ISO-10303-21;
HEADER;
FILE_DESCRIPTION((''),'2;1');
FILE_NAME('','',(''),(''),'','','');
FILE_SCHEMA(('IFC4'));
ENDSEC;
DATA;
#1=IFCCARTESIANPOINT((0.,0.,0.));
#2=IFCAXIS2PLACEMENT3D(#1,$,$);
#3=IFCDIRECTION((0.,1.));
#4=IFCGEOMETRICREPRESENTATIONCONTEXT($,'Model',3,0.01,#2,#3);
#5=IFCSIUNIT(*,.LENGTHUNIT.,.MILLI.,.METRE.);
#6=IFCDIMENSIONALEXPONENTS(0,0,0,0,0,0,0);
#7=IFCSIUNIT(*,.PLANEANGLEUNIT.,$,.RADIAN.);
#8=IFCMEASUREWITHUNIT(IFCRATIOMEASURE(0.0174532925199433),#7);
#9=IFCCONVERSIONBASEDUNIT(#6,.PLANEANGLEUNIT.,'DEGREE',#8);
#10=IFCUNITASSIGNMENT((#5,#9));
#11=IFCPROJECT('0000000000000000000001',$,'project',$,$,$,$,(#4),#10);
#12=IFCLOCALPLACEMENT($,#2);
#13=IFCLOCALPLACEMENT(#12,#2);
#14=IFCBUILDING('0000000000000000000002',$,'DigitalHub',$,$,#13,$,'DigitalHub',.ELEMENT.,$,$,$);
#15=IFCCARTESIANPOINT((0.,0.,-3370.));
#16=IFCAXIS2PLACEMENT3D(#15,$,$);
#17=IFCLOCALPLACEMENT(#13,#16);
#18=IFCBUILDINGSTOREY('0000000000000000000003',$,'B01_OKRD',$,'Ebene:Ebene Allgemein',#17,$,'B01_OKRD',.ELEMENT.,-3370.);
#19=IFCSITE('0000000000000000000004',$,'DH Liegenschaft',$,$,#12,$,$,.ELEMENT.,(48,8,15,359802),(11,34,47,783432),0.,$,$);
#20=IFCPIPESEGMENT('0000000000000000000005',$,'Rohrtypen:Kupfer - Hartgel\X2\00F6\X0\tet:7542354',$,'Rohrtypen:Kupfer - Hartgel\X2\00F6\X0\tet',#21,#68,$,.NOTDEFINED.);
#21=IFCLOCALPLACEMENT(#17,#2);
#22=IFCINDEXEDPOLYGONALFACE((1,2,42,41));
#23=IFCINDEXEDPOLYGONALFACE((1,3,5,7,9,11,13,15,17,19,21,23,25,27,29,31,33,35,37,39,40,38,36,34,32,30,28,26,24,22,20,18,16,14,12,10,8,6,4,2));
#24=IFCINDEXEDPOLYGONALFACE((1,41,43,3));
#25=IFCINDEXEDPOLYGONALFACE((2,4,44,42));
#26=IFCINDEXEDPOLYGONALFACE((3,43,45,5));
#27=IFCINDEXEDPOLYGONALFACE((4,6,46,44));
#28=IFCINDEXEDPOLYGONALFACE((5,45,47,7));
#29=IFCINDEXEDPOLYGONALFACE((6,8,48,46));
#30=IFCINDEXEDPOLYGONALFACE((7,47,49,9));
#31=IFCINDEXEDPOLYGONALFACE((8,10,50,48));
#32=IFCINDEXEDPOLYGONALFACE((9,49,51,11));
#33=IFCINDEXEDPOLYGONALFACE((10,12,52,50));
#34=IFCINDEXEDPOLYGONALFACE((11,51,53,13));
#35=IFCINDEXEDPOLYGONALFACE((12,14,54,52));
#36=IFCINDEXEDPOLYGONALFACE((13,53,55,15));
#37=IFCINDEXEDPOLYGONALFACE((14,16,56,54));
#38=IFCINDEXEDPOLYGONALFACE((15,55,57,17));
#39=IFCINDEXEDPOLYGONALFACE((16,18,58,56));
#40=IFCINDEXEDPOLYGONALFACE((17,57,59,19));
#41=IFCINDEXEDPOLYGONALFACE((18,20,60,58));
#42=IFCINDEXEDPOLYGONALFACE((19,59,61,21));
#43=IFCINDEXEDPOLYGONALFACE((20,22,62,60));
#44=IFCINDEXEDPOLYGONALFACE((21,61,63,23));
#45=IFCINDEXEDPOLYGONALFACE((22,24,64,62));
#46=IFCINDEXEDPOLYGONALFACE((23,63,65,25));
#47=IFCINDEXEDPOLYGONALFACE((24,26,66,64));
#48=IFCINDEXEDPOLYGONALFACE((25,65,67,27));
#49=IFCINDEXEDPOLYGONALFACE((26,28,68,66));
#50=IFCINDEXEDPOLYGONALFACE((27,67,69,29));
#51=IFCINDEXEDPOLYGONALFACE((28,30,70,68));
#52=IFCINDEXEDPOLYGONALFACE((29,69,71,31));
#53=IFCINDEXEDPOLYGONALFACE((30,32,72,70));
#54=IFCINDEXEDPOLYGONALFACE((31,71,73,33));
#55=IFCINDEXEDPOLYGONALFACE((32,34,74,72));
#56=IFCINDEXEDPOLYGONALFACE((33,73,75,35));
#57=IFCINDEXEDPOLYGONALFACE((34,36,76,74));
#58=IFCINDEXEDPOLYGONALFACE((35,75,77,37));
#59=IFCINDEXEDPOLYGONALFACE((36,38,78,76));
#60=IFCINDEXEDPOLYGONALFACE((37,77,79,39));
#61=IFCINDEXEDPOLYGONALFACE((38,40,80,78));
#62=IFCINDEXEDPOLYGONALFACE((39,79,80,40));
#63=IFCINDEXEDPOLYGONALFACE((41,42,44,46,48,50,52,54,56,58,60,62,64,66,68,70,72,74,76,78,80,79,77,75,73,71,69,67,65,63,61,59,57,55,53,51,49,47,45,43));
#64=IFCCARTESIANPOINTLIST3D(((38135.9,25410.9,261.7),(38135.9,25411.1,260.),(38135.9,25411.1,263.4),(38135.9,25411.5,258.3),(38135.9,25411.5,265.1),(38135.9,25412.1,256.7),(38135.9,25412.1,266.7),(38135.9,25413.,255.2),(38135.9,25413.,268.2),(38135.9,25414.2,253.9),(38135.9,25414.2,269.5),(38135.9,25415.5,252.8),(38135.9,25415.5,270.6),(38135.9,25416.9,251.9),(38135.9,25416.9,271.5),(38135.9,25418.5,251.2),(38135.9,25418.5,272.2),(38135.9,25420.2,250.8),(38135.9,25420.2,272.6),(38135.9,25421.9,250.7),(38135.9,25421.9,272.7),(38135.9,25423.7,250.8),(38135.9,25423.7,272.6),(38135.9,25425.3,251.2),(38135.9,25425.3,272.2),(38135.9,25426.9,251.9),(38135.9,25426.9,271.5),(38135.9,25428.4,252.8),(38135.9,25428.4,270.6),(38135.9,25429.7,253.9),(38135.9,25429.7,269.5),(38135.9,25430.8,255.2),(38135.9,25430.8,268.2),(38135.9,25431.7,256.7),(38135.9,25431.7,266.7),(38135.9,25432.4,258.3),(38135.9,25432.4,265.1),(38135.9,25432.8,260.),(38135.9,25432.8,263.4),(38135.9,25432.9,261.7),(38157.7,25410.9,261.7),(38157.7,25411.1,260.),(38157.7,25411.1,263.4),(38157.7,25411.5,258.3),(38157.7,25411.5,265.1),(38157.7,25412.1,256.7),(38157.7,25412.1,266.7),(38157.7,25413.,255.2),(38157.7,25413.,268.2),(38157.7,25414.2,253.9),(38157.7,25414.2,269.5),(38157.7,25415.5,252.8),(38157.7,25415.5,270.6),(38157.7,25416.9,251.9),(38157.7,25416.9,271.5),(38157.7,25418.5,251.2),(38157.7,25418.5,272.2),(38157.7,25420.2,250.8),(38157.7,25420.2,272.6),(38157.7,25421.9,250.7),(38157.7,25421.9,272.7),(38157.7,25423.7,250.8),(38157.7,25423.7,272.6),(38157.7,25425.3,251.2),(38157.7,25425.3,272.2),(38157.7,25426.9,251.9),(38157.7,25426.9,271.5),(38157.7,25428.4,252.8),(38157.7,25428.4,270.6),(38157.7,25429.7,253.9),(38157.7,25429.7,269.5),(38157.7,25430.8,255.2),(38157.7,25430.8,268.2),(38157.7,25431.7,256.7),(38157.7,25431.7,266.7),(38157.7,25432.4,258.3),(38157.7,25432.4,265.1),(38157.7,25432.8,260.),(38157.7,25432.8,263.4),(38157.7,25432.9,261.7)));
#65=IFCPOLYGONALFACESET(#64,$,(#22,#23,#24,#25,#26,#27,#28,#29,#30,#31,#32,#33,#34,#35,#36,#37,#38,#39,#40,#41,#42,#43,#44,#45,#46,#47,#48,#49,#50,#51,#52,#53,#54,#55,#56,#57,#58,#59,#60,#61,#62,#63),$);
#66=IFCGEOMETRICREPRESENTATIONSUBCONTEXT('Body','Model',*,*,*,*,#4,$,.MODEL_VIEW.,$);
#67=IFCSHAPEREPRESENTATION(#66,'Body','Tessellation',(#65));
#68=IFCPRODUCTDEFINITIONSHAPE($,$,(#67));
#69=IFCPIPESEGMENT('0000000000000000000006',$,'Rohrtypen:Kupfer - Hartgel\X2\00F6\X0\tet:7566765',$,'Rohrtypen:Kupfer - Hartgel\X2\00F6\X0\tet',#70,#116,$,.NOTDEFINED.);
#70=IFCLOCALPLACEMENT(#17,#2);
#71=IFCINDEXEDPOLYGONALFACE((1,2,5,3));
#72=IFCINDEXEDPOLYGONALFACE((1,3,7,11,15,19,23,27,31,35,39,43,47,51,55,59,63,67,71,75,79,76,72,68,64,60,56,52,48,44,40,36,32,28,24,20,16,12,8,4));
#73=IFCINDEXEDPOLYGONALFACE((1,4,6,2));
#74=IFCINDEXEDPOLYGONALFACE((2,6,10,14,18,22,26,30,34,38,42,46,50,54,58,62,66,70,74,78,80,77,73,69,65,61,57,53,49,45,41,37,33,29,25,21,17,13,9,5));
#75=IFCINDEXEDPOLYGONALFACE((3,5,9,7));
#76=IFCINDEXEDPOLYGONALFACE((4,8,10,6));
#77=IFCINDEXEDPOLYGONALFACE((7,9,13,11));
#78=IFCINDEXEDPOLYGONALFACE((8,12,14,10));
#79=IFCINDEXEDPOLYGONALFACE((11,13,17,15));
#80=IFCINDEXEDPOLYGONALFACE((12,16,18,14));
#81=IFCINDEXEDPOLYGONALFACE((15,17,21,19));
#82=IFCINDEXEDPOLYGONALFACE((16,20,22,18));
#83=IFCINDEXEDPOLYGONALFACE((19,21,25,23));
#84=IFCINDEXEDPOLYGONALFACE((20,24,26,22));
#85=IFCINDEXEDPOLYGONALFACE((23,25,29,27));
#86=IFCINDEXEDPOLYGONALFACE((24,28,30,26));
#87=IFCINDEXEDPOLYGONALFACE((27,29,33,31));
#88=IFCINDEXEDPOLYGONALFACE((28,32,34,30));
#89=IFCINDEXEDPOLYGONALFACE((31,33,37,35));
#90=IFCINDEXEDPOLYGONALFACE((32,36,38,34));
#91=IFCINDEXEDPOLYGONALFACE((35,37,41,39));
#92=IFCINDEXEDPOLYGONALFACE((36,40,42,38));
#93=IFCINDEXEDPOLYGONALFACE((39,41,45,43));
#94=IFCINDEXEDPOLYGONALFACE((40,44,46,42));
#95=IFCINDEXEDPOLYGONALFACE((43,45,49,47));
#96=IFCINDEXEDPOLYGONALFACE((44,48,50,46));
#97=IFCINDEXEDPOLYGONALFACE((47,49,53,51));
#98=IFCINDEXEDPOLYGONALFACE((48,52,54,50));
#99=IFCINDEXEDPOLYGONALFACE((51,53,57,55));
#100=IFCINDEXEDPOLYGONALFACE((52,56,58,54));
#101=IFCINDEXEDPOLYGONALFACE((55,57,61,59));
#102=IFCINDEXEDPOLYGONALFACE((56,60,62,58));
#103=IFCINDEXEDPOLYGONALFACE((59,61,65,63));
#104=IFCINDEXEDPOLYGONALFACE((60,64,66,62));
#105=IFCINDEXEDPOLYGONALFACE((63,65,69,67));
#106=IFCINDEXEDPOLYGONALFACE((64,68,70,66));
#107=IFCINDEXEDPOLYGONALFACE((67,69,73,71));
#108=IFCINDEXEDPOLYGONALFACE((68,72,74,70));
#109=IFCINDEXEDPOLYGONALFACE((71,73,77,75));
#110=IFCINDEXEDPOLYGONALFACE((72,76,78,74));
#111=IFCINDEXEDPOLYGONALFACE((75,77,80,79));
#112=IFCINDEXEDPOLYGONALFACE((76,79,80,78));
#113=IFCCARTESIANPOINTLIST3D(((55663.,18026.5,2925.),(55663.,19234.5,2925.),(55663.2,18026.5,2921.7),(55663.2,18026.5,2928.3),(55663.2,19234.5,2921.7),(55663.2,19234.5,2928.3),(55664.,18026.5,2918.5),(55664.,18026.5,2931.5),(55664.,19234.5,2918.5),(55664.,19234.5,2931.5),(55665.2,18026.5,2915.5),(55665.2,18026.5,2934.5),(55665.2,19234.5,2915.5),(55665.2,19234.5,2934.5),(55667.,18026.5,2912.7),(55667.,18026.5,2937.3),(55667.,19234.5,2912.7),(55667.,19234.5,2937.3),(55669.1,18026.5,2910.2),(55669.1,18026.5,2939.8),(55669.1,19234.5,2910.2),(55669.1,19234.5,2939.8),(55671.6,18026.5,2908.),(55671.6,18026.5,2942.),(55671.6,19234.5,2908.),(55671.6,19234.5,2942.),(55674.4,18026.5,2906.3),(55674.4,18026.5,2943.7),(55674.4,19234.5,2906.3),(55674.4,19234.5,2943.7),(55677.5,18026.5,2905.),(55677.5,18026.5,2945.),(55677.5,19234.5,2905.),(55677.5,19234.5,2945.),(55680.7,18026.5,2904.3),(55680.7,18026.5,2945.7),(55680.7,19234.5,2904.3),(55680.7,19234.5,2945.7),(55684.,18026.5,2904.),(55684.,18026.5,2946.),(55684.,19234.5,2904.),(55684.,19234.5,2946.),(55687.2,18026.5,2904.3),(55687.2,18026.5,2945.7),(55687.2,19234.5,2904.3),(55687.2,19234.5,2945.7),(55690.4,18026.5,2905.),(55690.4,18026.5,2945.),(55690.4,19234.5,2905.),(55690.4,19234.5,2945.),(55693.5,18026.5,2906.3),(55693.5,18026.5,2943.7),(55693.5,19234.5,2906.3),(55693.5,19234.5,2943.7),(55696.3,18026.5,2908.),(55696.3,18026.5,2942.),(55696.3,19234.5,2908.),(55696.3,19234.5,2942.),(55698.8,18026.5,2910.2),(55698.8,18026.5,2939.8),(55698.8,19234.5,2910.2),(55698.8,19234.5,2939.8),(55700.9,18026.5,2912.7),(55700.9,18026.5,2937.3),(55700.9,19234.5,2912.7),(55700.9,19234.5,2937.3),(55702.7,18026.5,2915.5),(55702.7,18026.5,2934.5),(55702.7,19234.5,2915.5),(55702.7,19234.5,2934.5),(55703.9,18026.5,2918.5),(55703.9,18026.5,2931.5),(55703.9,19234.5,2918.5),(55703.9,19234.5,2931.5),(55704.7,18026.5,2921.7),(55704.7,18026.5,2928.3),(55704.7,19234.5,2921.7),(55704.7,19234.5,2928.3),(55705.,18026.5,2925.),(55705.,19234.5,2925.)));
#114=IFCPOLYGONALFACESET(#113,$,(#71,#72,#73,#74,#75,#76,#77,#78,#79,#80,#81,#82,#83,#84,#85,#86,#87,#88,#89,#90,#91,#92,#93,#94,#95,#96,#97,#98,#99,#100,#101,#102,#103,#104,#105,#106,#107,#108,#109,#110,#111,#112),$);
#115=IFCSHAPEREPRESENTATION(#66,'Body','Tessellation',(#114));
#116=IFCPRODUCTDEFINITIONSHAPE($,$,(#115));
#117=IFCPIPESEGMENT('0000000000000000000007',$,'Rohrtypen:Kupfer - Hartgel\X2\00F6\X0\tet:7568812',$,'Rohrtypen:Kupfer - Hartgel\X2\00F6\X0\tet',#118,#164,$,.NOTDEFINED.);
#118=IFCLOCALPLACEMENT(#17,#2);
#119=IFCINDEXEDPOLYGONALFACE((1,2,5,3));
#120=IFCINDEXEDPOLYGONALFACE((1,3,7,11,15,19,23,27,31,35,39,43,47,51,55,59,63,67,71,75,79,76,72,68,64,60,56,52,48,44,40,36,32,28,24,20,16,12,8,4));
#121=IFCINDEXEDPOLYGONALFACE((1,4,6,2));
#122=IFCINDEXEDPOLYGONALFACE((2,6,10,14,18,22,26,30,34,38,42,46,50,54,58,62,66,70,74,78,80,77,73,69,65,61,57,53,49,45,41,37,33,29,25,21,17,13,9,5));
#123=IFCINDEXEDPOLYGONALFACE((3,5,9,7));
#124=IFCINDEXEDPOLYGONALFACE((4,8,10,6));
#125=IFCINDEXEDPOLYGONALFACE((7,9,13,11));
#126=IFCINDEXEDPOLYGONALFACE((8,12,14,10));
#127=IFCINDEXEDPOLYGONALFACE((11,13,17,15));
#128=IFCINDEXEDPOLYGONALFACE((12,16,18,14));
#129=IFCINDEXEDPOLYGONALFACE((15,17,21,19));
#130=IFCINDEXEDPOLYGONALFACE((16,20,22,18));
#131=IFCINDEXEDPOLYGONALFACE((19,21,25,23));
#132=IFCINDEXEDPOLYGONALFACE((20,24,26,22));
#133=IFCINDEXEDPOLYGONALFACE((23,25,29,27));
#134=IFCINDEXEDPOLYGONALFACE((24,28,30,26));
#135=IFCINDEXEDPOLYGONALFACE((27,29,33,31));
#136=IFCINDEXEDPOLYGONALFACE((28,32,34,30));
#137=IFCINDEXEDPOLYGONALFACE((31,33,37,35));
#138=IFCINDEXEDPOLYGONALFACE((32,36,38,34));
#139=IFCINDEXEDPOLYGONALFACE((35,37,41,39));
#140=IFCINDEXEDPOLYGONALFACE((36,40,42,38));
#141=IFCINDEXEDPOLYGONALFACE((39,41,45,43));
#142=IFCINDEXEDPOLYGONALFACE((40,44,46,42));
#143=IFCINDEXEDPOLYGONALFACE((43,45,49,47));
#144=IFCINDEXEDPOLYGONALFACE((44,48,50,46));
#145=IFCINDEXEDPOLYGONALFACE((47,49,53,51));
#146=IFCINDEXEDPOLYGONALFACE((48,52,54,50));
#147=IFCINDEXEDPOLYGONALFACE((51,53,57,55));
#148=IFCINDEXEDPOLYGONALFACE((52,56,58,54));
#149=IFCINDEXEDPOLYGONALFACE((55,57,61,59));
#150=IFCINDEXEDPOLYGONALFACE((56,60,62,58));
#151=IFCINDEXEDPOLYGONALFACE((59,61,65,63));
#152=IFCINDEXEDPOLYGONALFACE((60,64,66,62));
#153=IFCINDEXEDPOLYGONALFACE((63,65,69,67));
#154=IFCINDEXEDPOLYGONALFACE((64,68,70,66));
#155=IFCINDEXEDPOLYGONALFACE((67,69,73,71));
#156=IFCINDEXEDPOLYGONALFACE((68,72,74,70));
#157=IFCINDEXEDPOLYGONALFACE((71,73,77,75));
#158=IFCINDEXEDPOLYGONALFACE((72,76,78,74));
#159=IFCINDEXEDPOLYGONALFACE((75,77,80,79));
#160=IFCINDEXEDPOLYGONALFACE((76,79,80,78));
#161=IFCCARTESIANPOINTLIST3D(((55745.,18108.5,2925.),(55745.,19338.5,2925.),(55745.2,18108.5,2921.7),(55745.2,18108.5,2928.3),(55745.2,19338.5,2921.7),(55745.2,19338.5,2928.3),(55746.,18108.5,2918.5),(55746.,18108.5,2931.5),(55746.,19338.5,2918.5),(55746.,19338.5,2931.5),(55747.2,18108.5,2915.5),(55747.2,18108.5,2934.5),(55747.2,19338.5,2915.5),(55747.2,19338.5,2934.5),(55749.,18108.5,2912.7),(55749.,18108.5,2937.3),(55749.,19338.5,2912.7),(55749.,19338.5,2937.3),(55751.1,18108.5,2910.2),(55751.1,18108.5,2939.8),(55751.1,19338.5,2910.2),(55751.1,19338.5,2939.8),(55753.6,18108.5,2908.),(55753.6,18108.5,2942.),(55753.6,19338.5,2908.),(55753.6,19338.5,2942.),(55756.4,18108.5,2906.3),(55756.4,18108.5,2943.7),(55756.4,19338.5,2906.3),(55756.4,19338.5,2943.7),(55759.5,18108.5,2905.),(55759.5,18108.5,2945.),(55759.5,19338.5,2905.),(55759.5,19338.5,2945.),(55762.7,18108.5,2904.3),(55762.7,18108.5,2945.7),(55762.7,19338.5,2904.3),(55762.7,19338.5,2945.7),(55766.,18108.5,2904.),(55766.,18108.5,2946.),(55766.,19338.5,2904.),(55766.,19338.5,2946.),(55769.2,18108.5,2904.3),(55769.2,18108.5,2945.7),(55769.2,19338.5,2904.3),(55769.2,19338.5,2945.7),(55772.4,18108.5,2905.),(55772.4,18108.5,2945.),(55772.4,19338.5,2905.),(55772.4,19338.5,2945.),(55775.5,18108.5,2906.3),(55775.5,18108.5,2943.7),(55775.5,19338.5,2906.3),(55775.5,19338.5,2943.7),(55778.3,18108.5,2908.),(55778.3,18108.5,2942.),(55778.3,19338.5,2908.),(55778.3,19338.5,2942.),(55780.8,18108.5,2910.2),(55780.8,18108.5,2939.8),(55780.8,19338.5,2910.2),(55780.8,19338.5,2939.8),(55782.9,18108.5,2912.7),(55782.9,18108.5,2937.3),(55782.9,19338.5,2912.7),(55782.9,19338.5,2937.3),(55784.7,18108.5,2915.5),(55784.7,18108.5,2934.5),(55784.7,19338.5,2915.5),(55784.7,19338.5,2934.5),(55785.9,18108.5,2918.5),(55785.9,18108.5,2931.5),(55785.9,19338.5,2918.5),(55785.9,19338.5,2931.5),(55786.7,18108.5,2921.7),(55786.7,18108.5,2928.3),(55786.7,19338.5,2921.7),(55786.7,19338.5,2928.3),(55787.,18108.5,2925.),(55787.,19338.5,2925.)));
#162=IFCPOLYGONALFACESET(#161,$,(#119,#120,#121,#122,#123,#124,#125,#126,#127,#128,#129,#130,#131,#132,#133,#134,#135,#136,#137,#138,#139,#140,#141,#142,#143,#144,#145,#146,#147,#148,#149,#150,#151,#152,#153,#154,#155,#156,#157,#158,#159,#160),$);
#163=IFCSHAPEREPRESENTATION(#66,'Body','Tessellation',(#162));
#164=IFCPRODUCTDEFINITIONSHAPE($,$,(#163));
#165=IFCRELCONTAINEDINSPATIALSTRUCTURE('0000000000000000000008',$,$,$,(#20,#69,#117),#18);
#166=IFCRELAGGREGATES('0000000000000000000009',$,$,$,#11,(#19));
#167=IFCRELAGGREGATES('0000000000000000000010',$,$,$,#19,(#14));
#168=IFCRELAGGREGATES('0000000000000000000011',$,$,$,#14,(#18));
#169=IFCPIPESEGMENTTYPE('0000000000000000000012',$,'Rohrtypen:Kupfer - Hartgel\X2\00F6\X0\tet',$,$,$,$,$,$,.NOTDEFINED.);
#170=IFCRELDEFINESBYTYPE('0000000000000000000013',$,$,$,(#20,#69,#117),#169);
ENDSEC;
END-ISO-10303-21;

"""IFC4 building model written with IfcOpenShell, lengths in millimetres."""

from ifc_helpers import new_model, entity, si_unit, converted_unit, direction, frame, origin, place, context, subcontext, project, spatial, indexed_curve, outline, extrude, type_object, element, save


model = new_model("IFC4")

# Units and contexts
model_context = context("Model", 3, precision=0.01, world=origin(), true_north=direction((0.0, 1.0)))
body_context = subcontext(model_context, "Body", "Model", "MODEL_VIEW")
ifc_project = project(units=[si_unit("LENGTHUNIT", "METRE", prefix="MILLI"), converted_unit("PLANEANGLEUNIT", "DEGREE", entity("IfcRatioMeasure", 0.0174532925199433), si_unit("PLANEANGLEUNIT", "RADIAN"), dimensions=[0, 0, 0, 0, 0, 0, 0])], contexts=[model_context])

# Site, building, storey
site_placement = place(None, origin())
site = spatial("IfcSite", under=ifc_project, at=site_placement, Name="DH Liegenschaft", CompositionType="ELEMENT", RefLatitude=(48, 8, 15, 359802), RefLongitude=(11, 34, 47, 783432), RefElevation=0.0)
building_placement = place(site_placement, origin())
building = spatial("IfcBuilding", under=site, at=building_placement, Name="DigitalHub", LongName="DigitalHub", CompositionType="ELEMENT")
storey_placement = place(building_placement, frame((0.0, 0.0, -3370.0)))
storey = spatial("IfcBuildingStorey", under=building, at=storey_placement, Name="B01_OKRD", ObjectType="Ebene:Ebene Allgemein", LongName="B01_OKRD", CompositionType="ELEMENT", Elevation=-3370.0)

# Pipe segments
pipe_segment_type = type_object("IfcPipeSegmentType", Name="Rohrtypen:Kupfer - Hartgelötet", PredefinedType="NOTDEFINED")
pipe_segment_1_placement = place(storey_placement, frame((38135.9, 25409.3, 249.1)))
element("IfcPipeSegment", 1, at=pipe_segment_1_placement, inside=storey, type_object=pipe_segment_type, Name="Rohrtypen:Kupfer - Hartgelötet:7542354", ObjectType="Rohrtypen:Kupfer - Hartgelötet", PredefinedType="NOTDEFINED", context=body_context, shape_type="SweptSolid", body=[
    extrude(outline(indexed_curve([(11.0, 0.0), (10.9, 1.7), (10.5, 3.4), (9.8, 5.0), (8.9, 6.5), (7.8, 7.8), (6.5, 8.9), (5.0, 9.8), (3.4, 10.5), (1.7, 10.9), (0.0, 11.0), (-1.7, 10.9), (-3.4, 10.5), (-5.0, 9.8), (-6.5, 8.9), (-7.8, 7.8), (-8.9, 6.5), (-9.8, 5.0), (-10.5, 3.4), (-10.9, 1.7), (-11.0, 0.0), (-10.9, -1.7), (-10.5, -3.4), (-9.8, -5.0), (-8.9, -6.5), (-7.8, -7.8), (-6.5, -8.9), (-5.0, -9.8), (-3.4, -10.5), (-1.7, -10.9), (0.0, -11.0), (1.7, -10.9), (3.4, -10.5), (5.0, -9.8), (6.5, -8.9), (7.8, -7.8), (8.9, -6.5), (9.8, -5.0), (10.5, -3.4), (10.9, -1.7), (11.0, 0.0)], self_intersect=False)), frame((0.0, 12.6, 12.6), z_axis=(1.0, 0.0, 0.0), x_axis=(0.0, 1.0, 0.0)), (0.0, 0.0, 1.0), 21.8),
])
pipe_segment_2_placement = place(storey_placement, frame((55661.4, 18026.5, 2902.4)))
element("IfcPipeSegment", 2, at=pipe_segment_2_placement, inside=storey, type_object=pipe_segment_type, Name="Rohrtypen:Kupfer - Hartgelötet:7566765", ObjectType="Rohrtypen:Kupfer - Hartgelötet", PredefinedType="NOTDEFINED", context=body_context, shape_type="SweptSolid", body=[
    extrude(outline(indexed_curve([(21.0, 0.0), (20.7, 3.3), (20.0, 6.5), (18.7, 9.5), (17.0, 12.3), (14.8, 14.8), (12.3, 17.0), (9.5, 18.7), (6.5, 20.0), (3.3, 20.7), (0.0, 21.0), (-3.3, 20.7), (-6.5, 20.0), (-9.5, 18.7), (-12.3, 17.0), (-14.8, 14.8), (-17.0, 12.3), (-18.7, 9.5), (-20.0, 6.5), (-20.7, 3.3), (-21.0, 0.0), (-20.7, -3.3), (-20.0, -6.5), (-18.7, -9.5), (-17.0, -12.3), (-14.8, -14.8), (-12.3, -17.0), (-9.5, -18.7), (-6.5, -20.0), (-3.3, -20.7), (0.0, -21.0), (3.3, -20.7), (6.5, -20.0), (9.5, -18.7), (12.3, -17.0), (14.8, -14.8), (17.0, -12.3), (18.7, -9.5), (20.0, -6.5), (20.7, -3.3), (21.0, 0.0)], self_intersect=False)), frame((22.6, 0.0, 22.6), z_axis=(0.0, 1.0, 0.0), x_axis=(-1.0, 0.0, 0.0)), (0.0, 0.0, 1.0), 1208.0),
])
pipe_segment_3_placement = place(storey_placement, frame((55743.4, 18108.5, 2902.4)))
element("IfcPipeSegment", 3, at=pipe_segment_3_placement, inside=storey, type_object=pipe_segment_type, Name="Rohrtypen:Kupfer - Hartgelötet:7568812", ObjectType="Rohrtypen:Kupfer - Hartgelötet", PredefinedType="NOTDEFINED", context=body_context, shape_type="SweptSolid", body=[
    extrude(outline(indexed_curve([(21.0, 0.0), (20.7, 3.3), (20.0, 6.5), (18.7, 9.5), (17.0, 12.3), (14.8, 14.8), (12.3, 17.0), (9.5, 18.7), (6.5, 20.0), (3.3, 20.7), (0.0, 21.0), (-3.3, 20.7), (-6.5, 20.0), (-9.5, 18.7), (-12.3, 17.0), (-14.8, 14.8), (-17.0, 12.3), (-18.7, 9.5), (-20.0, 6.5), (-20.7, 3.3), (-21.0, 0.0), (-20.7, -3.3), (-20.0, -6.5), (-18.7, -9.5), (-17.0, -12.3), (-14.8, -14.8), (-12.3, -17.0), (-9.5, -18.7), (-6.5, -20.0), (-3.3, -20.7), (0.0, -21.0), (3.3, -20.7), (6.5, -20.0), (9.5, -18.7), (12.3, -17.0), (14.8, -14.8), (17.0, -12.3), (18.7, -9.5), (20.0, -6.5), (20.7, -3.3), (21.0, 0.0)], self_intersect=False)), frame((22.6, 0.0, 22.6), z_axis=(0.0, 1.0, 0.0), x_axis=(-1.0, 0.0, 0.0)), (0.0, 0.0, 1.0), 1230.0),
])

save(model, "model.ifc")
